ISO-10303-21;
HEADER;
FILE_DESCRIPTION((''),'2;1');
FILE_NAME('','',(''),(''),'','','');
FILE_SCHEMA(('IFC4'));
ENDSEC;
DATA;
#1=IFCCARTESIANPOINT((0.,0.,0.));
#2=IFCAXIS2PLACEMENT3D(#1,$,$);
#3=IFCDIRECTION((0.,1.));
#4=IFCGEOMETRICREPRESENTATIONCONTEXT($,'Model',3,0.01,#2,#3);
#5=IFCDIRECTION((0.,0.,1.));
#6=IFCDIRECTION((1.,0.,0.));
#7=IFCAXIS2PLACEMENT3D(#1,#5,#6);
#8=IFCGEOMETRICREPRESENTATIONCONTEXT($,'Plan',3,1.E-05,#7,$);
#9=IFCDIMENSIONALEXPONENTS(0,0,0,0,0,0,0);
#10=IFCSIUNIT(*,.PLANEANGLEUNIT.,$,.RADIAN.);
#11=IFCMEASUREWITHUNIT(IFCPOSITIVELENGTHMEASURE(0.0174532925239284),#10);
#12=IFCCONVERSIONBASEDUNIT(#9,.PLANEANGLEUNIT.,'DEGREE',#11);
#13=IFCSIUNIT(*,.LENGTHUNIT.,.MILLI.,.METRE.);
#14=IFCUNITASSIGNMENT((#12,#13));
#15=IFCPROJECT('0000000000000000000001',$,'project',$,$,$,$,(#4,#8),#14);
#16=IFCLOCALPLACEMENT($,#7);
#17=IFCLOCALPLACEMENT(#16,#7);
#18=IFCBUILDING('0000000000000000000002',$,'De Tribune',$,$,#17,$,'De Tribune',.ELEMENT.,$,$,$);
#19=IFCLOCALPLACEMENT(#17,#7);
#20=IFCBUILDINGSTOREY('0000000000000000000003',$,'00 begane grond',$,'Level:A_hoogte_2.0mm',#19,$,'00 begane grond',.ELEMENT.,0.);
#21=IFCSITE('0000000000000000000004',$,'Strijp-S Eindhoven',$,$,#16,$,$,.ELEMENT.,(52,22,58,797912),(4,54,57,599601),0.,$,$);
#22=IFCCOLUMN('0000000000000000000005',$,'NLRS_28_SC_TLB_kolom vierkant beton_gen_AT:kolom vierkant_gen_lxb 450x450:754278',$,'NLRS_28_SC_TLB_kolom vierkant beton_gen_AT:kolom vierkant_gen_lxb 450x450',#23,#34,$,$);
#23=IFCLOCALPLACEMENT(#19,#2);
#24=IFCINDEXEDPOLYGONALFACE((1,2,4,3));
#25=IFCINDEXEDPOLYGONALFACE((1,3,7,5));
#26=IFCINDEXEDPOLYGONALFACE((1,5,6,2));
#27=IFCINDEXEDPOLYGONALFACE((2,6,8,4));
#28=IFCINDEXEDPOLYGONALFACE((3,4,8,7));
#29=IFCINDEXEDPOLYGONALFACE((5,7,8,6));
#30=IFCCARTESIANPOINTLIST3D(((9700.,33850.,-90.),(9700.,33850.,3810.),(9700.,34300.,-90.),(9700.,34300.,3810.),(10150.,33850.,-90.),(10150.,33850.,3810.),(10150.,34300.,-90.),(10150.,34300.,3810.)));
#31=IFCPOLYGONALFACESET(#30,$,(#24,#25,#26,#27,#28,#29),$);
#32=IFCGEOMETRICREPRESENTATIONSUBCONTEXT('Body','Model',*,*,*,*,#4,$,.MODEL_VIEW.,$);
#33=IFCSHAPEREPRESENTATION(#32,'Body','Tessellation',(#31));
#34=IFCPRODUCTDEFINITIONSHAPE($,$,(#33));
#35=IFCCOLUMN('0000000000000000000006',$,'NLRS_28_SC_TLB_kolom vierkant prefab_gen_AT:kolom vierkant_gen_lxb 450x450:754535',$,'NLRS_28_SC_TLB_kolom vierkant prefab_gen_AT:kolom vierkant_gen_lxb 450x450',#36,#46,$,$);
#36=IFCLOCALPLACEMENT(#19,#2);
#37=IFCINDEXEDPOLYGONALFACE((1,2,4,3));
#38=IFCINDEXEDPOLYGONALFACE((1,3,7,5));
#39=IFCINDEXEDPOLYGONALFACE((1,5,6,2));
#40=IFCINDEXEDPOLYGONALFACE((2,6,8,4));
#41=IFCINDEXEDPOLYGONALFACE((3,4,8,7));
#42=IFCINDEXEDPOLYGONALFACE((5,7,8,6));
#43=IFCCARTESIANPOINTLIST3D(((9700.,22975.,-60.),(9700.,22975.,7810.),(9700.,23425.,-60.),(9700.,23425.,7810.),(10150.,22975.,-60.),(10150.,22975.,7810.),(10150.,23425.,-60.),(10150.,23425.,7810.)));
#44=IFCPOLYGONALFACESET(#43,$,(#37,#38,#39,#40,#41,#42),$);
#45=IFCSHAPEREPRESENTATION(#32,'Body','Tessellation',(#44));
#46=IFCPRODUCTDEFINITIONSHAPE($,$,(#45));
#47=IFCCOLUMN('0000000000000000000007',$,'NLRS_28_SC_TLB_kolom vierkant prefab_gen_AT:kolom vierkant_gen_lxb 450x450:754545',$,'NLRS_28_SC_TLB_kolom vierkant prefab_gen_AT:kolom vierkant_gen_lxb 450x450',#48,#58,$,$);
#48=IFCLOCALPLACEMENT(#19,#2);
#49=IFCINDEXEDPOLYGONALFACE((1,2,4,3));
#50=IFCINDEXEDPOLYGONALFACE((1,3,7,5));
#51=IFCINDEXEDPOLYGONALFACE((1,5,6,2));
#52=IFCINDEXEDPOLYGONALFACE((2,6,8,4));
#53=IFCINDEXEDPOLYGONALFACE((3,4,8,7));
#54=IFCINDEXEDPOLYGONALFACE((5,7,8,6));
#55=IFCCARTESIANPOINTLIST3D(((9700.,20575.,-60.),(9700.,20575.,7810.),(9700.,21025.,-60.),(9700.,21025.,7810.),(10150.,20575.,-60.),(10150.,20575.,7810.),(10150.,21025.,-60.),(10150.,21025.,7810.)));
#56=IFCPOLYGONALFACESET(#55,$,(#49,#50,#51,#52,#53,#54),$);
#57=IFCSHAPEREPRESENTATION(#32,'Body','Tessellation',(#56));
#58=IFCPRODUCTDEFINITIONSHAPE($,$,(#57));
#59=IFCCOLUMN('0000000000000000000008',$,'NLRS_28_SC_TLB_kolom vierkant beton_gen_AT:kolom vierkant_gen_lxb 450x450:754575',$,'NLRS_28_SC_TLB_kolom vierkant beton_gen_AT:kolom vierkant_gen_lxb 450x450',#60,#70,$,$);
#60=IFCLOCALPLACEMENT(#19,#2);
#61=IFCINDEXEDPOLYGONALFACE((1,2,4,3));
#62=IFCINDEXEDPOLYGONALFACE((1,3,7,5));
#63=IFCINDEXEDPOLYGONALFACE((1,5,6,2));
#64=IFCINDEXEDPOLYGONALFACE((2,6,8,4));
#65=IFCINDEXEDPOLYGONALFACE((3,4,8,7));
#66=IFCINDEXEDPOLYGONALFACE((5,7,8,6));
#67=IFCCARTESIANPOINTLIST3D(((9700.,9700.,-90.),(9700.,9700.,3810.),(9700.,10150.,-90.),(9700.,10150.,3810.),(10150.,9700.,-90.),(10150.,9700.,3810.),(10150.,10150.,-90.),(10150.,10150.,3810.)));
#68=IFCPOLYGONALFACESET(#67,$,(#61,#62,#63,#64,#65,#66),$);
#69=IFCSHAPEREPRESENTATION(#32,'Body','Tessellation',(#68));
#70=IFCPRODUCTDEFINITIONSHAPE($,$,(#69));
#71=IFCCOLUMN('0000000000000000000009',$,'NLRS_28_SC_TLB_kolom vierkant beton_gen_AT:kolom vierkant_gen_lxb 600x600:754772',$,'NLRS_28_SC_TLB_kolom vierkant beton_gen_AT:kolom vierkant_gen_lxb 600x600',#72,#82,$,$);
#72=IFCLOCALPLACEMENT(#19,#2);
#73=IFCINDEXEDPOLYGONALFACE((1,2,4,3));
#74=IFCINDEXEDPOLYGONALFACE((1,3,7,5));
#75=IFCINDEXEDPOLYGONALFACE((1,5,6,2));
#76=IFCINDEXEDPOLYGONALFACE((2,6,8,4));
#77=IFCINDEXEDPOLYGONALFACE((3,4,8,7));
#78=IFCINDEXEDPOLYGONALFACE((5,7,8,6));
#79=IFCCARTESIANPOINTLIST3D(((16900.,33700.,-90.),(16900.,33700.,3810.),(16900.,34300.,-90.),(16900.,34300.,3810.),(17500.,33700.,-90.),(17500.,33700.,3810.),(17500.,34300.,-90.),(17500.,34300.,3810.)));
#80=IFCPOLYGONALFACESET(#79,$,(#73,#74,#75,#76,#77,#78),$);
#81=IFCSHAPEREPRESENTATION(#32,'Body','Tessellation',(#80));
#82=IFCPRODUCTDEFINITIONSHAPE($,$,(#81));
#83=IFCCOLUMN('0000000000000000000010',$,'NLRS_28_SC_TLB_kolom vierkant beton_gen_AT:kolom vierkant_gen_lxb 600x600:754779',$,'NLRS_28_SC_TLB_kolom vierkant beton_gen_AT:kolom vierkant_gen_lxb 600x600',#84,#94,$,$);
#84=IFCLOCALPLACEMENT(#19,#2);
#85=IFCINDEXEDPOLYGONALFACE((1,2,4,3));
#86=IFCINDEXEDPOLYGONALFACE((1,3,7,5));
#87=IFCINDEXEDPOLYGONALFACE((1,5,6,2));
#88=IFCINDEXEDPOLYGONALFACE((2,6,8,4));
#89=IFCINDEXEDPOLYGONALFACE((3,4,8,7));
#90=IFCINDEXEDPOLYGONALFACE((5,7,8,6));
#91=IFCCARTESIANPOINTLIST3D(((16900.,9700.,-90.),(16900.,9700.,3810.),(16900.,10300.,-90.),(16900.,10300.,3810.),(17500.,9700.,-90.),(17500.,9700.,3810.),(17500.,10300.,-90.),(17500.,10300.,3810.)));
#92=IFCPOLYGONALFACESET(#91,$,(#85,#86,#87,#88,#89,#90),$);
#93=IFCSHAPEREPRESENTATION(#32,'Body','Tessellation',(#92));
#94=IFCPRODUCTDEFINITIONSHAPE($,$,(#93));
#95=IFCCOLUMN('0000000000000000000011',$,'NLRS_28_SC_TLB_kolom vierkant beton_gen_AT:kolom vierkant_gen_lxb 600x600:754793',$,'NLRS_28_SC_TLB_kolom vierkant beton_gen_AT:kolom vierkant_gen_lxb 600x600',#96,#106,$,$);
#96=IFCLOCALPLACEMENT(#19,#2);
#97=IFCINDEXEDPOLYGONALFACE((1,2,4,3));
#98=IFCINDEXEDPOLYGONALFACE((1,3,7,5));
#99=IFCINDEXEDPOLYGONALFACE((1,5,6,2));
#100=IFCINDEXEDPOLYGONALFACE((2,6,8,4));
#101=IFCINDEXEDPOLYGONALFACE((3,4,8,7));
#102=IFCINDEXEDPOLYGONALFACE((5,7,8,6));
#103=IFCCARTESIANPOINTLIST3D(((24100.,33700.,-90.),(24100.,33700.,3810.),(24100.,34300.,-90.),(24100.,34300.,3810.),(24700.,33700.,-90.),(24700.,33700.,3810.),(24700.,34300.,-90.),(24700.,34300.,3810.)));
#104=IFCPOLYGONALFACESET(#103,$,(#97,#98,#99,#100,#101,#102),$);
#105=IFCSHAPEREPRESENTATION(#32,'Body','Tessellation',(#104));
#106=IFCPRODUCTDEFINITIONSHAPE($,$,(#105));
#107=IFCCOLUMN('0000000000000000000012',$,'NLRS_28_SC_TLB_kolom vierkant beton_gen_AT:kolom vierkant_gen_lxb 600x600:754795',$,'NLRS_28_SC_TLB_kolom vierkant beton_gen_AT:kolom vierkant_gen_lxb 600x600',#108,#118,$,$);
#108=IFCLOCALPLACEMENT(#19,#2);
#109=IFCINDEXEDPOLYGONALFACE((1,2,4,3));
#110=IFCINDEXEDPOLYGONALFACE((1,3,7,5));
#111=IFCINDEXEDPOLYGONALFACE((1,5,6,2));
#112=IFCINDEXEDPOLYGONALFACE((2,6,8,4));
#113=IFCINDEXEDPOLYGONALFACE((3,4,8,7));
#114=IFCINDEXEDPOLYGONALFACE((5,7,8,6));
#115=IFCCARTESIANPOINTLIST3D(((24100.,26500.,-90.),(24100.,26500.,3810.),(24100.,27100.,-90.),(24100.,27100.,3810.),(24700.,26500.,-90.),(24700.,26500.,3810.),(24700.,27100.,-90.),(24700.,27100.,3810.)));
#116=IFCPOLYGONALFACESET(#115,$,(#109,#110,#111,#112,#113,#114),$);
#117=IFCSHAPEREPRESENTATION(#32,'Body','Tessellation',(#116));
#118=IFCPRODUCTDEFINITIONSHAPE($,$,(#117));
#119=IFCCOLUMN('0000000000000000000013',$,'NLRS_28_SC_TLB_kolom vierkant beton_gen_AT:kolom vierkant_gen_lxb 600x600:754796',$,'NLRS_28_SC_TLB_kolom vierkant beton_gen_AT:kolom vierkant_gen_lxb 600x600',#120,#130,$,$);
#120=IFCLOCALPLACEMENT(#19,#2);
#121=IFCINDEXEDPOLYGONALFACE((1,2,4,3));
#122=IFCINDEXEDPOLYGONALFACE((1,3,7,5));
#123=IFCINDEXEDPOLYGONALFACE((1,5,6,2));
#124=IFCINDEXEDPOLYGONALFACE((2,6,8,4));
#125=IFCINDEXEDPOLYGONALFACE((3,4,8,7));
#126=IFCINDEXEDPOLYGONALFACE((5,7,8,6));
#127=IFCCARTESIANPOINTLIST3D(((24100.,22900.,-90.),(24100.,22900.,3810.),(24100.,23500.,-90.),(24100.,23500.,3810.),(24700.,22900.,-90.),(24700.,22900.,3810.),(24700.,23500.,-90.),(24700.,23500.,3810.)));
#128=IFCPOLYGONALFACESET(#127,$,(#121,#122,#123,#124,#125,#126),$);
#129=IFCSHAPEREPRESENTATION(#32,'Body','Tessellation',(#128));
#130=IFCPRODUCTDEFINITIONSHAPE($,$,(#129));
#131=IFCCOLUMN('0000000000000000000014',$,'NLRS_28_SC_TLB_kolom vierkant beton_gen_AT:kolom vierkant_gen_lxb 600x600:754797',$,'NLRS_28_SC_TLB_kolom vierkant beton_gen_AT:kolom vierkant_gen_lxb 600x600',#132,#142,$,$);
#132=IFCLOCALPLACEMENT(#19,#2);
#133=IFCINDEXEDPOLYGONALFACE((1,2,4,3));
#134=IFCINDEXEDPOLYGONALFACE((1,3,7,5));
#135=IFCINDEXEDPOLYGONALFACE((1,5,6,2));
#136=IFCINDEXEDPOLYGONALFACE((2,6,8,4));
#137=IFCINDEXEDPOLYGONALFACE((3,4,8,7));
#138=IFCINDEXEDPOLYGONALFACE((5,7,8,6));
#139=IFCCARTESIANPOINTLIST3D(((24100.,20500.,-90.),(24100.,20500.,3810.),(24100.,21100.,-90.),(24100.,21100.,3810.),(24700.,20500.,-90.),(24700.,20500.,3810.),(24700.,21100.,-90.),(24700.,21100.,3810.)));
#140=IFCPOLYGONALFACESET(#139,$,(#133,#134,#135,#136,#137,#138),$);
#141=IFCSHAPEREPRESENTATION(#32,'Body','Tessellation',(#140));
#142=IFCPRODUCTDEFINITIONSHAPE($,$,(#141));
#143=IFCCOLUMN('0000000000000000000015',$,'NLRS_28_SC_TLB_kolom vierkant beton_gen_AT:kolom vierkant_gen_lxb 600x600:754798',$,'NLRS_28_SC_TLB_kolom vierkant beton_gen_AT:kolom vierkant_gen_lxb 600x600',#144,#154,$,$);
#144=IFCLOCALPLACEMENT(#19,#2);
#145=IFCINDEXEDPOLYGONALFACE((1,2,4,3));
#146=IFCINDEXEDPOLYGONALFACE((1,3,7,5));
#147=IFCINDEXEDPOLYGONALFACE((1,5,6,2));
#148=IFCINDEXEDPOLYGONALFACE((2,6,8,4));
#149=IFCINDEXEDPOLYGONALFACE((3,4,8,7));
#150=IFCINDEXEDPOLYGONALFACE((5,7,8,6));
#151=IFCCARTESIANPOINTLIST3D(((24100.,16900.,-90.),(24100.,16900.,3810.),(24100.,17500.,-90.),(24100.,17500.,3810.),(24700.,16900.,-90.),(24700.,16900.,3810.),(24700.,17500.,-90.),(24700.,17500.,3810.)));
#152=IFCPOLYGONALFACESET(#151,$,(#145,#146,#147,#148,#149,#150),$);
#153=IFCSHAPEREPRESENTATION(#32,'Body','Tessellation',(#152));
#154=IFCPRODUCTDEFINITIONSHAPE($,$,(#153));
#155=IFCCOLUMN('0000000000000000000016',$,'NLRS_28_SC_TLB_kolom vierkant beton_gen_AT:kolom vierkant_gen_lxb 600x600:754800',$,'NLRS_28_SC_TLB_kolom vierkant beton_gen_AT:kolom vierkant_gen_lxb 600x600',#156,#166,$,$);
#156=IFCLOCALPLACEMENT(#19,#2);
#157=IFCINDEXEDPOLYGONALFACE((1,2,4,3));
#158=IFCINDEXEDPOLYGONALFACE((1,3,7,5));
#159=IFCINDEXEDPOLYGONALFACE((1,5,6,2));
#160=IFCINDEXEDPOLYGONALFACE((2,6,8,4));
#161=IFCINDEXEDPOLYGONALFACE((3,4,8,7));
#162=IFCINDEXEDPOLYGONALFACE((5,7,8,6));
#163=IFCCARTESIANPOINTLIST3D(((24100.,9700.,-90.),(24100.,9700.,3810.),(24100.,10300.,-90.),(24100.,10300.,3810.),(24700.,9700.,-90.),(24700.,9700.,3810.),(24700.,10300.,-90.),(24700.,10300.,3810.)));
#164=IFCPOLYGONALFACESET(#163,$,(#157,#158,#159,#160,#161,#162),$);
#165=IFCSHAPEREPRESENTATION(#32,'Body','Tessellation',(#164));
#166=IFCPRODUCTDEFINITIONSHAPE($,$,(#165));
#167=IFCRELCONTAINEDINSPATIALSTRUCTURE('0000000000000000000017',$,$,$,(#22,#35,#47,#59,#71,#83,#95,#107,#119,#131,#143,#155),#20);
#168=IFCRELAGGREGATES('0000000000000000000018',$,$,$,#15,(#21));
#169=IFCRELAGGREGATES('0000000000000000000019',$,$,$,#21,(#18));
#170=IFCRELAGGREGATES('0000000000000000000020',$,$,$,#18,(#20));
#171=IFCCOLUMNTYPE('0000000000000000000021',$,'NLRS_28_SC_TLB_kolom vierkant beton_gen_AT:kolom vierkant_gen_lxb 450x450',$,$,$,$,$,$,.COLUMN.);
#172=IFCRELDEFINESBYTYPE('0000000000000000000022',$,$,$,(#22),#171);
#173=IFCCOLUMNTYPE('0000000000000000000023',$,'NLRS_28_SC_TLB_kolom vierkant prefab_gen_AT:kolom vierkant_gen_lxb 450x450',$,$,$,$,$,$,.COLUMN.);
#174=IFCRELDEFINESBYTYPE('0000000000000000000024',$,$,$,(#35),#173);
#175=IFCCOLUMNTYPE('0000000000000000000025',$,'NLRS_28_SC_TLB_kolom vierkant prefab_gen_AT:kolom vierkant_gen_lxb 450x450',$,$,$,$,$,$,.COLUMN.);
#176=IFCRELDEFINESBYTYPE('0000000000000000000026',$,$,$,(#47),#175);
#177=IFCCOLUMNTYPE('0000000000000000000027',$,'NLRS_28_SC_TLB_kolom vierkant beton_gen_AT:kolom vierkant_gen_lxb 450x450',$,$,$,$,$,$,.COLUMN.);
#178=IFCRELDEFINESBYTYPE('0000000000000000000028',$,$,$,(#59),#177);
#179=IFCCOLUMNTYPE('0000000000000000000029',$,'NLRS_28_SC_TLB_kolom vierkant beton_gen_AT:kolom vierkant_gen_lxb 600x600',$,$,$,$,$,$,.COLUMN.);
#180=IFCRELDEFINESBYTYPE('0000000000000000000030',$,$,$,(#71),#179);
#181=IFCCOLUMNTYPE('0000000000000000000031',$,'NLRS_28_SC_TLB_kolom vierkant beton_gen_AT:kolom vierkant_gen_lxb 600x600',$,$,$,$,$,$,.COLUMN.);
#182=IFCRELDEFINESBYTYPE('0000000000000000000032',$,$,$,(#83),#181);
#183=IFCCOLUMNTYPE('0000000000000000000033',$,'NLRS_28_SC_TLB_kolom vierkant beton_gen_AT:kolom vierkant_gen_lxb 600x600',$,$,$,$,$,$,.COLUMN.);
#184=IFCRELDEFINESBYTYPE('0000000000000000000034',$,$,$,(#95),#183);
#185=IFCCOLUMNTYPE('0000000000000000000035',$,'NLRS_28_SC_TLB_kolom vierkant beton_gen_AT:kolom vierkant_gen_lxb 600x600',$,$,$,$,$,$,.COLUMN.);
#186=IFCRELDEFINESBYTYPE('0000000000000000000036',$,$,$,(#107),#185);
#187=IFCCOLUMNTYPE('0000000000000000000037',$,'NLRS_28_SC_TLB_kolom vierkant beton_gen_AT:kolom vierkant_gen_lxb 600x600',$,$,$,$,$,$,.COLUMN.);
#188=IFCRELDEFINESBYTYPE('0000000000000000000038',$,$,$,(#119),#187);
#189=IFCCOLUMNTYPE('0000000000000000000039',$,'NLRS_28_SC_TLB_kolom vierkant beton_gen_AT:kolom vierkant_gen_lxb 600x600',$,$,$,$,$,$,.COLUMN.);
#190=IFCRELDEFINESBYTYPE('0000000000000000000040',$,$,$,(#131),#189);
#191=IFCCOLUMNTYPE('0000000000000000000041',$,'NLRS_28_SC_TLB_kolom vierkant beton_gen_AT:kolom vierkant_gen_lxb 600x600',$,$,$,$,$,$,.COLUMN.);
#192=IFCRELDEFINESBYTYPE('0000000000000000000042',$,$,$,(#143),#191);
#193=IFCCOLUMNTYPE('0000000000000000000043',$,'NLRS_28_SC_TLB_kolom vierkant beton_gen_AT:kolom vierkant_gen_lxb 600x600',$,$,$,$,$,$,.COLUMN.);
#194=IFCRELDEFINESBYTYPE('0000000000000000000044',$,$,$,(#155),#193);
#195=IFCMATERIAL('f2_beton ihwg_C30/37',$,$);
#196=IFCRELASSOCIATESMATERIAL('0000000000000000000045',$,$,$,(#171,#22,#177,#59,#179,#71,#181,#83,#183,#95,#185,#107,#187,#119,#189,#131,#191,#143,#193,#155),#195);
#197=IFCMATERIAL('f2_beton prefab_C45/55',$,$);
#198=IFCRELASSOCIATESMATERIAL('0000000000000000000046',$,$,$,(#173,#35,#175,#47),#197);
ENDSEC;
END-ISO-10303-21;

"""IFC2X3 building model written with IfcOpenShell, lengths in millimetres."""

from ifc_helpers import new_model, entity, si_unit, converted_unit, direction, frame, frame_2d, origin, origin_with_axes, place, context, subcontext, project, spatial, rectangle, extrude, source, transform, mapped, material, type_object, element, save


model = new_model("IFC2X3")

# Units and contexts
model_context = context("Model", 3, precision=0.01, world=origin(), true_north=direction((0.0, 1.0)))
plan_context = context("Plan", 3, precision=1e-05, world=origin_with_axes())
body_context = subcontext(model_context, "Body", "Model", "MODEL_VIEW")
ifc_project = project(units=[converted_unit("PLANEANGLEUNIT", "DEGREE", entity("IfcPositiveLengthMeasure", 0.0174532925239284), si_unit("PLANEANGLEUNIT", "RADIAN"), dimensions=[0, 0, 0, 0, 0, 0, 0]), si_unit("LENGTHUNIT", "METRE", prefix="MILLI")], contexts=[model_context, plan_context])

# Site, building, storey
site_placement = place(None, origin_with_axes())
site = spatial("IfcSite", under=ifc_project, at=site_placement, Name="Strijp-S Eindhoven", CompositionType="ELEMENT", RefLatitude=(52, 22, 58, 797912), RefLongitude=(4, 54, 57, 599601), RefElevation=0.0)
building_placement = place(site_placement, origin_with_axes())
building = spatial("IfcBuilding", under=site, at=building_placement, Name="De Tribune", LongName="De Tribune", CompositionType="ELEMENT")
storey_placement = place(building_placement, origin_with_axes())
storey = spatial("IfcBuildingStorey", under=building, at=storey_placement, Name="00 begane grond", ObjectType="Level:A_hoogte_2.0mm", LongName="00 begane grond", CompositionType="ELEMENT", Elevation=0.0)

# Columns
ifc_material_1 = material(Name="f2_beton ihwg_C30/37")
column_type_1 = type_object("IfcColumnType", Name="NLRS_28_SC_TLB_kolom vierkant beton_gen_AT:kolom vierkant_gen_lxb 450x450", PredefinedType="COLUMN", material=ifc_material_1)
shared_shape_1 = source(origin(), body_context, "Body", "SweptSolid", [
    extrude(rectangle(XDim=450.0, YDim=450.0, at=frame_2d((0.0, 0.0), x_axis=(1.0, 0.0))), frame((9925.0, 34075.0, -90.0), z_axis=(0.0, 0.0, 1.0), x_axis=(-1.0, 0.0, 0.0)), (0.0, 0.0, 1.0), 3900.0),
])
column_1_placement = place(storey_placement, origin_with_axes())
element("IfcColumn", 1, at=column_1_placement, inside=storey, type_object=column_type_1, material=ifc_material_1, Name="NLRS_28_SC_TLB_kolom vierkant beton_gen_AT:kolom vierkant_gen_lxb 450x450:754278", ObjectType="NLRS_28_SC_TLB_kolom vierkant beton_gen_AT:kolom vierkant_gen_lxb 450x450", context=body_context, shape_type="MappedRepresentation", body=[
    mapped(shared_shape_1, transform((0.0, 0.0, 0.0), scale=1.0)),
])
ifc_material_2 = material(Name="f2_beton prefab_C45/55")
column_type_2 = type_object("IfcColumnType", Name="NLRS_28_SC_TLB_kolom vierkant prefab_gen_AT:kolom vierkant_gen_lxb 450x450", PredefinedType="COLUMN", material=ifc_material_2)
shared_shape_2 = source(origin(), body_context, "Body", "SweptSolid", [
    extrude(rectangle(XDim=450.0, YDim=450.0, at=frame_2d((0.0, 0.0), x_axis=(1.0, 0.0))), frame((9925.0, 23200.0, -60.0), z_axis=(0.0, 0.0, 1.0), x_axis=(-1.0, 0.0, 0.0)), (0.0, 0.0, 1.0), 7870.0),
])
column_2_placement = place(storey_placement, origin_with_axes())
element("IfcColumn", 2, at=column_2_placement, inside=storey, type_object=column_type_2, material=ifc_material_2, Name="NLRS_28_SC_TLB_kolom vierkant prefab_gen_AT:kolom vierkant_gen_lxb 450x450:754535", ObjectType="NLRS_28_SC_TLB_kolom vierkant prefab_gen_AT:kolom vierkant_gen_lxb 450x450", context=body_context, shape_type="MappedRepresentation", body=[
    mapped(shared_shape_2, transform((0.0, 0.0, 0.0), scale=1.0)),
])
column_type_3 = type_object("IfcColumnType", Name="NLRS_28_SC_TLB_kolom vierkant prefab_gen_AT:kolom vierkant_gen_lxb 450x450", PredefinedType="COLUMN", material=ifc_material_2)
shared_shape_3 = source(origin(), body_context, "Body", "SweptSolid", [
    extrude(rectangle(XDim=450.0, YDim=450.0, at=frame_2d((0.0, 0.0), x_axis=(1.0, 0.0))), frame((9925.0, 20800.0, -60.0), z_axis=(0.0, 0.0, 1.0), x_axis=(-1.0, 0.0, 0.0)), (0.0, 0.0, 1.0), 7870.0),
])
column_3_placement = place(storey_placement, origin_with_axes())
element("IfcColumn", 3, at=column_3_placement, inside=storey, type_object=column_type_3, material=ifc_material_2, Name="NLRS_28_SC_TLB_kolom vierkant prefab_gen_AT:kolom vierkant_gen_lxb 450x450:754545", ObjectType="NLRS_28_SC_TLB_kolom vierkant prefab_gen_AT:kolom vierkant_gen_lxb 450x450", context=body_context, shape_type="MappedRepresentation", body=[
    mapped(shared_shape_3, transform((0.0, 0.0, 0.0), scale=1.0)),
])
column_type_4 = type_object("IfcColumnType", Name="NLRS_28_SC_TLB_kolom vierkant beton_gen_AT:kolom vierkant_gen_lxb 450x450", PredefinedType="COLUMN", material=ifc_material_1)
shared_shape_4 = source(origin(), body_context, "Body", "SweptSolid", [
    extrude(rectangle(XDim=450.0, YDim=450.0, at=frame_2d((0.0, 0.0), x_axis=(1.0, 0.0))), frame((9925.0, 9925.0, -90.0), z_axis=(0.0, 0.0, 1.0), x_axis=(-1.0, 0.0, 0.0)), (0.0, 0.0, 1.0), 3900.0),
])
column_4_placement = place(storey_placement, origin_with_axes())
element("IfcColumn", 4, at=column_4_placement, inside=storey, type_object=column_type_4, material=ifc_material_1, Name="NLRS_28_SC_TLB_kolom vierkant beton_gen_AT:kolom vierkant_gen_lxb 450x450:754575", ObjectType="NLRS_28_SC_TLB_kolom vierkant beton_gen_AT:kolom vierkant_gen_lxb 450x450", context=body_context, shape_type="MappedRepresentation", body=[
    mapped(shared_shape_4, transform((0.0, 0.0, 0.0), scale=1.0)),
])
column_type_5 = type_object("IfcColumnType", Name="NLRS_28_SC_TLB_kolom vierkant beton_gen_AT:kolom vierkant_gen_lxb 600x600", PredefinedType="COLUMN", material=ifc_material_1)
shared_shape_5 = source(origin(), body_context, "Body", "SweptSolid", [
    extrude(rectangle(XDim=600.0, YDim=600.0, at=frame_2d((0.0, 0.0), x_axis=(1.0, 0.0))), frame((17200.0, 34000.0, -90.0), z_axis=(0.0, 0.0, 1.0), x_axis=(-1.0, 0.0, 0.0)), (0.0, 0.0, 1.0), 3900.0),
])
column_5_placement = place(storey_placement, origin_with_axes())
element("IfcColumn", 5, at=column_5_placement, inside=storey, type_object=column_type_5, material=ifc_material_1, Name="NLRS_28_SC_TLB_kolom vierkant beton_gen_AT:kolom vierkant_gen_lxb 600x600:754772", ObjectType="NLRS_28_SC_TLB_kolom vierkant beton_gen_AT:kolom vierkant_gen_lxb 600x600", context=body_context, shape_type="MappedRepresentation", body=[
    mapped(shared_shape_5, transform((0.0, 0.0, 0.0), scale=1.0)),
])
column_type_6 = type_object("IfcColumnType", Name="NLRS_28_SC_TLB_kolom vierkant beton_gen_AT:kolom vierkant_gen_lxb 600x600", PredefinedType="COLUMN", material=ifc_material_1)
shared_shape_6 = source(origin(), body_context, "Body", "SweptSolid", [
    extrude(rectangle(XDim=600.0, YDim=600.0, at=frame_2d((0.0, 0.0), x_axis=(1.0, 0.0))), frame((17200.0, 10000.0, -90.0), z_axis=(0.0, 0.0, 1.0), x_axis=(-1.0, 0.0, 0.0)), (0.0, 0.0, 1.0), 3900.0),
])
column_6_placement = place(storey_placement, origin_with_axes())
element("IfcColumn", 6, at=column_6_placement, inside=storey, type_object=column_type_6, material=ifc_material_1, Name="NLRS_28_SC_TLB_kolom vierkant beton_gen_AT:kolom vierkant_gen_lxb 600x600:754779", ObjectType="NLRS_28_SC_TLB_kolom vierkant beton_gen_AT:kolom vierkant_gen_lxb 600x600", context=body_context, shape_type="MappedRepresentation", body=[
    mapped(shared_shape_6, transform((0.0, 0.0, 0.0), scale=1.0)),
])
column_type_7 = type_object("IfcColumnType", Name="NLRS_28_SC_TLB_kolom vierkant beton_gen_AT:kolom vierkant_gen_lxb 600x600", PredefinedType="COLUMN", material=ifc_material_1)
shared_shape_7 = source(origin(), body_context, "Body", "SweptSolid", [
    extrude(rectangle(XDim=600.0, YDim=600.0, at=frame_2d((0.0, 0.0), x_axis=(1.0, 0.0))), frame((24400.0, 34000.0, -90.0), z_axis=(0.0, 0.0, 1.0), x_axis=(-1.0, 0.0, 0.0)), (0.0, 0.0, 1.0), 3900.0),
])
column_7_placement = place(storey_placement, origin_with_axes())
element("IfcColumn", 7, at=column_7_placement, inside=storey, type_object=column_type_7, material=ifc_material_1, Name="NLRS_28_SC_TLB_kolom vierkant beton_gen_AT:kolom vierkant_gen_lxb 600x600:754793", ObjectType="NLRS_28_SC_TLB_kolom vierkant beton_gen_AT:kolom vierkant_gen_lxb 600x600", context=body_context, shape_type="MappedRepresentation", body=[
    mapped(shared_shape_7, transform((0.0, 0.0, 0.0), scale=1.0)),
])
column_type_8 = type_object("IfcColumnType", Name="NLRS_28_SC_TLB_kolom vierkant beton_gen_AT:kolom vierkant_gen_lxb 600x600", PredefinedType="COLUMN", material=ifc_material_1)
shared_shape_8 = source(origin(), body_context, "Body", "SweptSolid", [
    extrude(rectangle(XDim=600.0, YDim=600.0, at=frame_2d((0.0, 0.0), x_axis=(1.0, 0.0))), frame((24400.0, 26800.0, -90.0), z_axis=(0.0, 0.0, 1.0), x_axis=(-1.0, 0.0, 0.0)), (0.0, 0.0, 1.0), 3900.0),
])
column_8_placement = place(storey_placement, origin_with_axes())
element("IfcColumn", 8, at=column_8_placement, inside=storey, type_object=column_type_8, material=ifc_material_1, Name="NLRS_28_SC_TLB_kolom vierkant beton_gen_AT:kolom vierkant_gen_lxb 600x600:754795", ObjectType="NLRS_28_SC_TLB_kolom vierkant beton_gen_AT:kolom vierkant_gen_lxb 600x600", context=body_context, shape_type="MappedRepresentation", body=[
    mapped(shared_shape_8, transform((0.0, 0.0, 0.0), scale=1.0)),
])
column_type_9 = type_object("IfcColumnType", Name="NLRS_28_SC_TLB_kolom vierkant beton_gen_AT:kolom vierkant_gen_lxb 600x600", PredefinedType="COLUMN", material=ifc_material_1)
shared_shape_9 = source(origin(), body_context, "Body", "SweptSolid", [
    extrude(rectangle(XDim=600.0, YDim=600.0, at=frame_2d((0.0, 0.0), x_axis=(1.0, 0.0))), frame((24400.0, 23200.0, -90.0), z_axis=(0.0, 0.0, 1.0), x_axis=(-1.0, 0.0, 0.0)), (0.0, 0.0, 1.0), 3900.0),
])
column_9_placement = place(storey_placement, origin_with_axes())
element("IfcColumn", 9, at=column_9_placement, inside=storey, type_object=column_type_9, material=ifc_material_1, Name="NLRS_28_SC_TLB_kolom vierkant beton_gen_AT:kolom vierkant_gen_lxb 600x600:754796", ObjectType="NLRS_28_SC_TLB_kolom vierkant beton_gen_AT:kolom vierkant_gen_lxb 600x600", context=body_context, shape_type="MappedRepresentation", body=[
    mapped(shared_shape_9, transform((0.0, 0.0, 0.0), scale=1.0)),
])
column_type_10 = type_object("IfcColumnType", Name="NLRS_28_SC_TLB_kolom vierkant beton_gen_AT:kolom vierkant_gen_lxb 600x600", PredefinedType="COLUMN", material=ifc_material_1)
shared_shape_10 = source(origin(), body_context, "Body", "SweptSolid", [
    extrude(rectangle(XDim=600.0, YDim=600.0, at=frame_2d((0.0, 0.0), x_axis=(1.0, 0.0))), frame((24400.0, 20800.0, -90.0), z_axis=(0.0, 0.0, 1.0), x_axis=(-1.0, 0.0, 0.0)), (0.0, 0.0, 1.0), 3900.0),
])
column_10_placement = place(storey_placement, origin_with_axes())
element("IfcColumn", 10, at=column_10_placement, inside=storey, type_object=column_type_10, material=ifc_material_1, Name="NLRS_28_SC_TLB_kolom vierkant beton_gen_AT:kolom vierkant_gen_lxb 600x600:754797", ObjectType="NLRS_28_SC_TLB_kolom vierkant beton_gen_AT:kolom vierkant_gen_lxb 600x600", context=body_context, shape_type="MappedRepresentation", body=[
    mapped(shared_shape_10, transform((0.0, 0.0, 0.0), scale=1.0)),
])
column_type_11 = type_object("IfcColumnType", Name="NLRS_28_SC_TLB_kolom vierkant beton_gen_AT:kolom vierkant_gen_lxb 600x600", PredefinedType="COLUMN", material=ifc_material_1)
shared_shape_11 = source(origin(), body_context, "Body", "SweptSolid", [
    extrude(rectangle(XDim=600.0, YDim=600.0, at=frame_2d((0.0, 0.0), x_axis=(1.0, 0.0))), frame((24400.0, 17200.0, -90.0), z_axis=(0.0, 0.0, 1.0), x_axis=(-1.0, 0.0, 0.0)), (0.0, 0.0, 1.0), 3900.0),
])
column_11_placement = place(storey_placement, origin_with_axes())
element("IfcColumn", 11, at=column_11_placement, inside=storey, type_object=column_type_11, material=ifc_material_1, Name="NLRS_28_SC_TLB_kolom vierkant beton_gen_AT:kolom vierkant_gen_lxb 600x600:754798", ObjectType="NLRS_28_SC_TLB_kolom vierkant beton_gen_AT:kolom vierkant_gen_lxb 600x600", context=body_context, shape_type="MappedRepresentation", body=[
    mapped(shared_shape_11, transform((0.0, 0.0, 0.0), scale=1.0)),
])
column_type_12 = type_object("IfcColumnType", Name="NLRS_28_SC_TLB_kolom vierkant beton_gen_AT:kolom vierkant_gen_lxb 600x600", PredefinedType="COLUMN", material=ifc_material_1)
shared_shape_12 = source(origin(), body_context, "Body", "SweptSolid", [
    extrude(rectangle(XDim=600.0, YDim=600.0, at=frame_2d((0.0, 0.0), x_axis=(1.0, 0.0))), frame((24400.0, 10000.0, -90.0), z_axis=(0.0, 0.0, 1.0), x_axis=(-1.0, 0.0, 0.0)), (0.0, 0.0, 1.0), 3900.0),
])
column_12_placement = place(storey_placement, origin_with_axes())
element("IfcColumn", 12, at=column_12_placement, inside=storey, type_object=column_type_12, material=ifc_material_1, Name="NLRS_28_SC_TLB_kolom vierkant beton_gen_AT:kolom vierkant_gen_lxb 600x600:754800", ObjectType="NLRS_28_SC_TLB_kolom vierkant beton_gen_AT:kolom vierkant_gen_lxb 600x600", context=body_context, shape_type="MappedRepresentation", body=[
    mapped(shared_shape_12, transform((0.0, 0.0, 0.0), scale=1.0)),
])

save(model, "model.ifc")
